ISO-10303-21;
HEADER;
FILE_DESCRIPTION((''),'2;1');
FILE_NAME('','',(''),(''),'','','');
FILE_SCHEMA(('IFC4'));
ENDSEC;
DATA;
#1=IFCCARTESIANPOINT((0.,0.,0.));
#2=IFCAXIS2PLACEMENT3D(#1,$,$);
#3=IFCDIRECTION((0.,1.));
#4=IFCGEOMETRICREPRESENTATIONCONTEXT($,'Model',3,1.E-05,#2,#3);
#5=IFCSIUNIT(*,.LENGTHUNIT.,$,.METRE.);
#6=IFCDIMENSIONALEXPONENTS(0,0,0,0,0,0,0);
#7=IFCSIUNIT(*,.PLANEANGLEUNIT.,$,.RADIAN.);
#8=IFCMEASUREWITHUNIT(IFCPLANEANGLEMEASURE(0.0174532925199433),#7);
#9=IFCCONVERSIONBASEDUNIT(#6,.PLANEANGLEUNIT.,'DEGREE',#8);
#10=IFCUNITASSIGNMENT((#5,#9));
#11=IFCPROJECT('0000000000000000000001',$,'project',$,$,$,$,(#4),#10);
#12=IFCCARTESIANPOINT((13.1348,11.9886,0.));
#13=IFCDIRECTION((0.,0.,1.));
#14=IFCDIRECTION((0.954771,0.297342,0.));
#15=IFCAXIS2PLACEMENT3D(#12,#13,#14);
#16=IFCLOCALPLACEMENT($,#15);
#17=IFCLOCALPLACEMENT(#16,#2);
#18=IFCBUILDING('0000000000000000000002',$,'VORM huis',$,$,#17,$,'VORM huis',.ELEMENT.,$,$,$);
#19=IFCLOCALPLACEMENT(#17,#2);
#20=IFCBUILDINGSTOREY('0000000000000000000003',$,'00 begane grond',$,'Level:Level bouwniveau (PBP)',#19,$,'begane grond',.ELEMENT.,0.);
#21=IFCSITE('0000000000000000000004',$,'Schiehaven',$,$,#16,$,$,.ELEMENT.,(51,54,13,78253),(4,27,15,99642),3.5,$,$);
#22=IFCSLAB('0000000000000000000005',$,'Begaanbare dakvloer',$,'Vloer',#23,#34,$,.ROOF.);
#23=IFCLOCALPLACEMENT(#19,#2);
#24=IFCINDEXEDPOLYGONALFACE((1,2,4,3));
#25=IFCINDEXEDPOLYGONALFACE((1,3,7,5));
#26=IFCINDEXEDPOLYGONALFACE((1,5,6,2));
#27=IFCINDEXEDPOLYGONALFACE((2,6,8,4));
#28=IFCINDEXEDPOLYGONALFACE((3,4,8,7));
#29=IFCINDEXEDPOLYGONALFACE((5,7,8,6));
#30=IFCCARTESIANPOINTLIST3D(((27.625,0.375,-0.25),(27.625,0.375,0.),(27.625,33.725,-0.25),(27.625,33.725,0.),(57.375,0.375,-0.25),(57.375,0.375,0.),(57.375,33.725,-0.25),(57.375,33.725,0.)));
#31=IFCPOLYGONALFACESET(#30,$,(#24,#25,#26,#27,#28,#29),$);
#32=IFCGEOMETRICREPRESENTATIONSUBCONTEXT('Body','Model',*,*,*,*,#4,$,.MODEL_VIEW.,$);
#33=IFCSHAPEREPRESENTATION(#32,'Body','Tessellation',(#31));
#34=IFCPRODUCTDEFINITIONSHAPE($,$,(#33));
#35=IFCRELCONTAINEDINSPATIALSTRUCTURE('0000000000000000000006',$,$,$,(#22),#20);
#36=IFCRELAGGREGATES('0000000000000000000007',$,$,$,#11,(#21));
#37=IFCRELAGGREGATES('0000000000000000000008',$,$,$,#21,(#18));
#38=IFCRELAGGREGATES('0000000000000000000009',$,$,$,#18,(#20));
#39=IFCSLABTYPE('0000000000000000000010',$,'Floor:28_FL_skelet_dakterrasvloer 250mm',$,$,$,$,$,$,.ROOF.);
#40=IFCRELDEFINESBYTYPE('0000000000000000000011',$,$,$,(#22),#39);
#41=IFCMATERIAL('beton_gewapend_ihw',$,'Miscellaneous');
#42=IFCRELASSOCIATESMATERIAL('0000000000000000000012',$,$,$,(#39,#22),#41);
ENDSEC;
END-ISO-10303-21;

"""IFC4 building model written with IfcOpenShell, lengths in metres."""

from ifc_helpers import new_model, entity, si_unit, converted_unit, direction, frame, origin, place, context, subcontext, project, spatial, indexed_curve, outline, extrude, material, type_object, element, save


model = new_model("IFC4")

# Units and contexts
model_context = context("Model", 3, precision=1e-05, world=origin(), true_north=direction((0.0, 1.0)))
body_context = subcontext(model_context, "Body", "Model", "MODEL_VIEW")
ifc_project = project(units=[si_unit("LENGTHUNIT", "METRE"), converted_unit("PLANEANGLEUNIT", "DEGREE", entity("IfcPlaneAngleMeasure", 0.0174532925199433), si_unit("PLANEANGLEUNIT", "RADIAN"), dimensions=[0, 0, 0, 0, 0, 0, 0])], contexts=[model_context])

# Site, building, storey
site_placement = place(None, frame((13.1348, 11.9886, 0.0), z_axis=(0.0, 0.0, 1.0), x_axis=(0.954771, 0.297342, 0.0)))
site = spatial("IfcSite", under=ifc_project, at=site_placement, Name="Schiehaven", CompositionType="ELEMENT", RefLatitude=(51, 54, 13, 78253), RefLongitude=(4, 27, 15, 99642), RefElevation=3.5)
building_placement = place(site_placement, origin())
building = spatial("IfcBuilding", under=site, at=building_placement, Name="VORM huis", LongName="VORM huis", CompositionType="ELEMENT")
storey_placement = place(building_placement, origin())
storey = spatial("IfcBuildingStorey", under=building, at=storey_placement, Name="00 begane grond", ObjectType="Level:Level bouwniveau (PBP)", LongName="begane grond", CompositionType="ELEMENT", Elevation=0.0)

# Slab
ifc_material = material(Name="beton_gewapend_ihw", Category="Miscellaneous")
slab_type = type_object("IfcSlabType", Name="Floor:28_FL_skelet_dakterrasvloer 250mm", PredefinedType="ROOF", material=ifc_material)
slab_placement = place(storey_placement, origin())
element("IfcSlab", 1, at=slab_placement, inside=storey, type_object=slab_type, material=ifc_material, Name="Begaanbare dakvloer", ObjectType="Vloer", PredefinedType="ROOF", context=body_context, shape_type="SweptSolid", body=[
    extrude(outline(indexed_curve([(-16.675, -14.875), (16.675, -14.875), (16.675, 14.875), (-16.675, 14.875), (-16.675, -14.875)], self_intersect=False)), frame((42.5, 17.05, 0.0), z_axis=(0.0, 0.0, -1.0), x_axis=(0.0, 1.0, 0.0)), (0.0, 0.0, 1.0), 0.25),
])

save(model, "model.ifc")
